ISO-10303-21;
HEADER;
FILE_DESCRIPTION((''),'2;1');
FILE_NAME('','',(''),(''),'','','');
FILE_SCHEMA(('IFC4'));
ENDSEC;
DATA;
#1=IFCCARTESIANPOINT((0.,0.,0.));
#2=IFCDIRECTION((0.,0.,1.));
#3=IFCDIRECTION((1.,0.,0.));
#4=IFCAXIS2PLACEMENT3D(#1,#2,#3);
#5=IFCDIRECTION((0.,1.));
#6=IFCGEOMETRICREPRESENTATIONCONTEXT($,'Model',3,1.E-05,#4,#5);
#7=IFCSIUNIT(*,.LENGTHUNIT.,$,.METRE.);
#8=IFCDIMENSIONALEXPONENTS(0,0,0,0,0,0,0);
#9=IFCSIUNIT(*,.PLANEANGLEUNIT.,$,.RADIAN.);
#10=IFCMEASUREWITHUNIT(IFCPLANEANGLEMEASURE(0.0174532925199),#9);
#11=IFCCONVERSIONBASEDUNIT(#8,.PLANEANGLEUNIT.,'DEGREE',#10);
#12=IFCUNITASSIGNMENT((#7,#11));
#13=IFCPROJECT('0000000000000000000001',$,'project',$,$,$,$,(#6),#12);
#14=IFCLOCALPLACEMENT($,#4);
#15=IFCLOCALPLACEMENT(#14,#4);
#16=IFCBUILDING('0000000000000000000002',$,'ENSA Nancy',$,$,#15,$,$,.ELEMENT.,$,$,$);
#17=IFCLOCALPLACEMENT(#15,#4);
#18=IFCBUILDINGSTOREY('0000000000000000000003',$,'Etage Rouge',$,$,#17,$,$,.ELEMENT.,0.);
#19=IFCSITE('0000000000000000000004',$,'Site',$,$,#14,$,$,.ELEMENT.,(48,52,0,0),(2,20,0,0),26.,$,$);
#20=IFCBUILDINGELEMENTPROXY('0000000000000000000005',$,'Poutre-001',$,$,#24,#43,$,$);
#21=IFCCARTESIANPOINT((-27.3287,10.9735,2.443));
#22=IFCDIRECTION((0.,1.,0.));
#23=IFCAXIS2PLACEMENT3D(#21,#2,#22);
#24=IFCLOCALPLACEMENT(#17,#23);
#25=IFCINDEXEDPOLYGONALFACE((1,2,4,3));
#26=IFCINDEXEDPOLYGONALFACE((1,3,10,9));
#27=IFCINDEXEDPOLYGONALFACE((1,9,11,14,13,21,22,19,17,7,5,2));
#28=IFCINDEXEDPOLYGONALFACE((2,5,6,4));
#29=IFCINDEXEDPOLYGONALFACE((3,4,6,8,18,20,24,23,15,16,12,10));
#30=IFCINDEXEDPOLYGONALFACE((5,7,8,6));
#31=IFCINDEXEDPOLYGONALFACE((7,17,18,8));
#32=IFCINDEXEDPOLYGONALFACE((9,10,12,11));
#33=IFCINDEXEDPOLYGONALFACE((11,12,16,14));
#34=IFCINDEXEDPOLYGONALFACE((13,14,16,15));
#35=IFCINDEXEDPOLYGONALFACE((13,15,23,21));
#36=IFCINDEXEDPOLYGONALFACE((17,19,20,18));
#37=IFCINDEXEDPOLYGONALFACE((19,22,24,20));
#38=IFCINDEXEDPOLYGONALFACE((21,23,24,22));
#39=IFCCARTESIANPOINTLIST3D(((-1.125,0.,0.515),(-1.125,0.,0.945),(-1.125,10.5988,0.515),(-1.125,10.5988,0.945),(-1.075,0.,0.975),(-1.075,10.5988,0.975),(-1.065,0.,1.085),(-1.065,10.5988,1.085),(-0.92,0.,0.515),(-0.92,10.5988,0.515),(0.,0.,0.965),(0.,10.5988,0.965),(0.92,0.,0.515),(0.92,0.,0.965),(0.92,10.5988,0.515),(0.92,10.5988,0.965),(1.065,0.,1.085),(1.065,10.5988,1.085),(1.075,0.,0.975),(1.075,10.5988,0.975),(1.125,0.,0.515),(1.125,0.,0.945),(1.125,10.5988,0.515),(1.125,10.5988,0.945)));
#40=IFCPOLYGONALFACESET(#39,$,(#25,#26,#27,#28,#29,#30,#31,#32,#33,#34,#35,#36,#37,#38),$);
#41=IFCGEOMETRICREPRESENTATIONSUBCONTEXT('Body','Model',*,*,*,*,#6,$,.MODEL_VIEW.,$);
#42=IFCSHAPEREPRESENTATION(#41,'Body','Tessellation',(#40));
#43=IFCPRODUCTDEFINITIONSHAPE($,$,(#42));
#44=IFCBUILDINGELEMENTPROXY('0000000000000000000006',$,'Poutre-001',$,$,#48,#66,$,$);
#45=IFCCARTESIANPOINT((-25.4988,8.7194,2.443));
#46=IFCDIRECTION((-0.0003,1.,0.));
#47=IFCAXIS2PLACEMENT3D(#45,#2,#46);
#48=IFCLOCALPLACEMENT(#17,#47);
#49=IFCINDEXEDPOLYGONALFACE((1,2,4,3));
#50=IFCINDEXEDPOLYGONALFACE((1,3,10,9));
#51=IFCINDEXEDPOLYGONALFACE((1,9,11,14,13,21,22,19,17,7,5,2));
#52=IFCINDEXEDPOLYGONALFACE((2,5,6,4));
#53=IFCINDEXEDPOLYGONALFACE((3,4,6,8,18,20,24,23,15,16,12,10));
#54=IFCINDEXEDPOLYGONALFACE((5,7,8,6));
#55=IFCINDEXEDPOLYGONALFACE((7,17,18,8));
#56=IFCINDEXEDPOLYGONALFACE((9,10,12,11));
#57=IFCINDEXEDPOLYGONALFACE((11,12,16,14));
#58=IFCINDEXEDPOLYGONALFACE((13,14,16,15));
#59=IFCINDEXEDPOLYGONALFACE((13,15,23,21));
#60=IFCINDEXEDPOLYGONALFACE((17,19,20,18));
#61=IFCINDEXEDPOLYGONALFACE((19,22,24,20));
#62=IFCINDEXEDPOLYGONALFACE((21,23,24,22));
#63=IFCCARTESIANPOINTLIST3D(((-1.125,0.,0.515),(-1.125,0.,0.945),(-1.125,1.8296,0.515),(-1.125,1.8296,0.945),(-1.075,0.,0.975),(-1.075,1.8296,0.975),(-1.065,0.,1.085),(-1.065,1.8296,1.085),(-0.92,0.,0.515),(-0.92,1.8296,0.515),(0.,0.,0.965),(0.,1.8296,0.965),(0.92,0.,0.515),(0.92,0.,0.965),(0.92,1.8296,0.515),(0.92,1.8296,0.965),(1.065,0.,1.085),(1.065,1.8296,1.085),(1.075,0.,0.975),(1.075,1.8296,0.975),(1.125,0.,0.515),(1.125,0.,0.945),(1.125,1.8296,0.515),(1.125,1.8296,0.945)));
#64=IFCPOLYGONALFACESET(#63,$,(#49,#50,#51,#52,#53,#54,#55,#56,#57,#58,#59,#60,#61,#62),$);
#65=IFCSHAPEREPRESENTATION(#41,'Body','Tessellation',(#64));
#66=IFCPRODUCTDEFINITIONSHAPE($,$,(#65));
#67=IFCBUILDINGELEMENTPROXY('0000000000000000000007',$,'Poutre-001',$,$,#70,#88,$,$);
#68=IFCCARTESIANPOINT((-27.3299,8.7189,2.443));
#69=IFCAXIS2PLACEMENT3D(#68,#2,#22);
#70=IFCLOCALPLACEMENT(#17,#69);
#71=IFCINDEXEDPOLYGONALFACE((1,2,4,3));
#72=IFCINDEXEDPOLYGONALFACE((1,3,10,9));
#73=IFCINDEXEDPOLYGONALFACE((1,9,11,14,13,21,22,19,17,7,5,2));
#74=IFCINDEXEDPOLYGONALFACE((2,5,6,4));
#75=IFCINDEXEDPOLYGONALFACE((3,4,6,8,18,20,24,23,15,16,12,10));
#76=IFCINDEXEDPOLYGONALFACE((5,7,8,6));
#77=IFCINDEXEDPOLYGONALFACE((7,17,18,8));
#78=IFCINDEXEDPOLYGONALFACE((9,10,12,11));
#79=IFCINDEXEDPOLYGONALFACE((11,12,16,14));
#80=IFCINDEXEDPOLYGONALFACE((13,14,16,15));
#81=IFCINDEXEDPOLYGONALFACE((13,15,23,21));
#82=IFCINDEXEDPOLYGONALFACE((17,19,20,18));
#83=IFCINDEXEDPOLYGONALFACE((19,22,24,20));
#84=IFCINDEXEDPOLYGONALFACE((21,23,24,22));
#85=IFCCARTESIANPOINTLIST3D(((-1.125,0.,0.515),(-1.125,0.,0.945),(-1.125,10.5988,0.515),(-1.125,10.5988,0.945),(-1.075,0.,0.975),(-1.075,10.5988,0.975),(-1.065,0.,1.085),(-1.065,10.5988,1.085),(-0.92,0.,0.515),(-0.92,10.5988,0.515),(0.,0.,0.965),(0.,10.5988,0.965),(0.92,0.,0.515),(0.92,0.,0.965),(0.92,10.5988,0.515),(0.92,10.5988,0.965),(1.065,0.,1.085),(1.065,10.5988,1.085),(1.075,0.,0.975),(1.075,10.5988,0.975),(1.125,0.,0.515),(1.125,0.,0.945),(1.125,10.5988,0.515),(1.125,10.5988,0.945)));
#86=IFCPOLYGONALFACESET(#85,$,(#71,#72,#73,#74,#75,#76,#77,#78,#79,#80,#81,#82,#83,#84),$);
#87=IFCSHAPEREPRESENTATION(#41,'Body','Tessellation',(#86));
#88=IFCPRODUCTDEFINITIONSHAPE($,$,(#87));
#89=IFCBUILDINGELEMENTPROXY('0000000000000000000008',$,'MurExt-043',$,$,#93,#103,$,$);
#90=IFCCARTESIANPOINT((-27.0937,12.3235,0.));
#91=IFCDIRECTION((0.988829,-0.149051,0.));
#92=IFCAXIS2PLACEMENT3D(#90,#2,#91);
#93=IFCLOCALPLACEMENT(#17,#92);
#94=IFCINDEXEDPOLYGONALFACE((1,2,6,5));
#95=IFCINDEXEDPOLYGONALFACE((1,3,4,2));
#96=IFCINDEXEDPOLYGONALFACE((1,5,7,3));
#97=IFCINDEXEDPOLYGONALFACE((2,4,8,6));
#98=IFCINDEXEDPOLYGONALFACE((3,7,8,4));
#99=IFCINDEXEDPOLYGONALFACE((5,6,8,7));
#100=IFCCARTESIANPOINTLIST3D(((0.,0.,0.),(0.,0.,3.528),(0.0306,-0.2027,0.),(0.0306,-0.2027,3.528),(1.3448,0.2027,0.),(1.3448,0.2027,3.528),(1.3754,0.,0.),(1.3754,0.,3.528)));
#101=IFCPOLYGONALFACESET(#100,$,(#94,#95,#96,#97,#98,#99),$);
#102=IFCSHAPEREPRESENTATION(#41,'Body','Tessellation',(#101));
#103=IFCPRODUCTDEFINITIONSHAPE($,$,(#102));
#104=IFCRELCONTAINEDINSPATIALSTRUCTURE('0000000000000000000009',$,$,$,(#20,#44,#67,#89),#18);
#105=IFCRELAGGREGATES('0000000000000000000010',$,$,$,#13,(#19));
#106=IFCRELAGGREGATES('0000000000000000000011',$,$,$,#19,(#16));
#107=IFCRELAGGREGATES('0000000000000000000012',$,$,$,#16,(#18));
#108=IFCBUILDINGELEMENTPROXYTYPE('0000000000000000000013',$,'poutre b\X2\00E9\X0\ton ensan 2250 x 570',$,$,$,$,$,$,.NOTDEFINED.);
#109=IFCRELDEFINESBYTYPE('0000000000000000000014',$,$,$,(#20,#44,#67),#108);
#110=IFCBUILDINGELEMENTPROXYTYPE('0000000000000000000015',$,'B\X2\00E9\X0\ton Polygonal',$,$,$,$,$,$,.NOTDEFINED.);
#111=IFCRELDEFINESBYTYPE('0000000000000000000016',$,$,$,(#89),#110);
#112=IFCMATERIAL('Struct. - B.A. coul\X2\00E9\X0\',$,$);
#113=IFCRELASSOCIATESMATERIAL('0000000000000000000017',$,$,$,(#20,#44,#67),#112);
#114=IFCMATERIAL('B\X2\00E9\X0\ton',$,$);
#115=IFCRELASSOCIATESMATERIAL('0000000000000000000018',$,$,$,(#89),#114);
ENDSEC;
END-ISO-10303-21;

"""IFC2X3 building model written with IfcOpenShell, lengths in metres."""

from ifc_helpers import new_model, entity, si_unit, converted_unit, direction, frame, origin_with_axes, place, context, subcontext, project, spatial, polyline, outline, extrude, material, type_object, element, save


model = new_model("IFC2X3")

# Units and contexts
model_context = context("Model", 3, precision=1e-05, world=origin_with_axes(), true_north=direction((0.0, 1.0)))
body_context = subcontext(model_context, "Body", "Model", "MODEL_VIEW")
ifc_project = project(units=[si_unit("LENGTHUNIT", "METRE"), converted_unit("PLANEANGLEUNIT", "DEGREE", entity("IfcPlaneAngleMeasure", 0.0174532925199), si_unit("PLANEANGLEUNIT", "RADIAN"), dimensions=[0, 0, 0, 0, 0, 0, 0])], contexts=[model_context])

# Site, building, storey
site_placement = place(None, origin_with_axes())
site = spatial("IfcSite", under=ifc_project, at=site_placement, Name="Site", CompositionType="ELEMENT", RefLatitude=(48, 52, 0, 0), RefLongitude=(2, 20, 0, 0), RefElevation=26.0)
building_placement = place(site_placement, origin_with_axes())
building = spatial("IfcBuilding", under=site, at=building_placement, Name="ENSA Nancy", CompositionType="ELEMENT")
storey_placement = place(building_placement, origin_with_axes())
storey = spatial("IfcBuildingStorey", under=building, at=storey_placement, Name="Etage Rouge", CompositionType="ELEMENT", Elevation=0.0)

# Building element proxies
ifc_material_1 = material(Name="Béton")
ifc_material_2 = material(Name="Struct. - B.A. coulé")
building_element_proxy_type_1 = type_object("IfcBuildingElementProxyType", Name="poutre béton ensan 2250 x 570", PredefinedType="NOTDEFINED")
proxy_1_placement = place(storey_placement, frame((-27.3287, 10.9735, 2.443), z_axis=(0.0, 0.0, 1.0), x_axis=(0.0, 1.0, 0.0)))
element("IfcBuildingElementProxy", 1, at=proxy_1_placement, inside=storey, type_object=building_element_proxy_type_1, material=ifc_material_2, Name="Poutre-001", context=body_context, shape_type="SweptSolid", body=[
    extrude(outline(polyline([(-1.065, 1.085), (-1.075, 0.975), (-1.125, 0.945), (-1.125, 0.515), (-0.92, 0.515), (0.0, 0.965), (0.92, 0.965), (0.92, 0.515), (1.125, 0.515), (1.125, 0.945), (1.075, 0.975), (1.065, 1.085), (-1.065, 1.085)])), frame((0.0, 10.5988, 0.0), z_axis=(0.0, -1.0, 0.0), x_axis=(1.0, 0.0, 0.0)), (0.0, 0.0, 1.0), 10.5988),
])
proxy_2_placement = place(storey_placement, frame((-25.4988, 8.7194, 2.443), z_axis=(0.0, 0.0, 1.0), x_axis=(-0.0003, 1.0, 0.0)))
element("IfcBuildingElementProxy", 2, at=proxy_2_placement, inside=storey, type_object=building_element_proxy_type_1, material=ifc_material_2, Name="Poutre-001", context=body_context, shape_type="SweptSolid", body=[
    extrude(outline(polyline([(-1.065, 1.085), (-1.075, 0.975), (-1.125, 0.945), (-1.125, 0.515), (-0.92, 0.515), (0.0, 0.965), (0.92, 0.965), (0.92, 0.515), (1.125, 0.515), (1.125, 0.945), (1.075, 0.975), (1.065, 1.085), (-1.065, 1.085)])), frame((0.0, 1.8296, 0.0), z_axis=(0.0, -1.0, 0.0), x_axis=(1.0, 0.0, 0.0)), (0.0, 0.0, 1.0), 1.8296),
])
proxy_3_placement = place(storey_placement, frame((-27.3299, 8.7189, 2.443), z_axis=(0.0, 0.0, 1.0), x_axis=(0.0, 1.0, 0.0)))
element("IfcBuildingElementProxy", 3, at=proxy_3_placement, inside=storey, type_object=building_element_proxy_type_1, material=ifc_material_2, Name="Poutre-001", context=body_context, shape_type="SweptSolid", body=[
    extrude(outline(polyline([(-1.065, 1.085), (-1.075, 0.975), (-1.125, 0.945), (-1.125, 0.515), (-0.92, 0.515), (0.0, 0.965), (0.92, 0.965), (0.92, 0.515), (1.125, 0.515), (1.125, 0.945), (1.075, 0.975), (1.065, 1.085), (-1.065, 1.085)])), frame((0.0, 10.5988, 0.0), z_axis=(0.0, -1.0, 0.0), x_axis=(1.0, 0.0, 0.0)), (0.0, 0.0, 1.0), 10.5988),
])
building_element_proxy_type_2 = type_object("IfcBuildingElementProxyType", Name="Béton Polygonal", PredefinedType="NOTDEFINED")
proxy_4_placement = place(storey_placement, frame((-27.0937, 12.3235, 0.0), z_axis=(0.0, 0.0, 1.0), x_axis=(0.988829, -0.149051, 0.0)))
element("IfcBuildingElementProxy", 4, at=proxy_4_placement, inside=storey, type_object=building_element_proxy_type_2, material=ifc_material_1, Name="MurExt-043", context=body_context, shape_type="SweptSolid", body=[
    extrude(outline(polyline([(0.0, 0.0), (0.0306, -0.2027), (1.3754, 0.0), (1.3448, 0.2027), (0.0, 0.0)])), origin_with_axes(), (0.0, 0.0, 1.0), 3.528),
])

save(model, "model.ifc")
